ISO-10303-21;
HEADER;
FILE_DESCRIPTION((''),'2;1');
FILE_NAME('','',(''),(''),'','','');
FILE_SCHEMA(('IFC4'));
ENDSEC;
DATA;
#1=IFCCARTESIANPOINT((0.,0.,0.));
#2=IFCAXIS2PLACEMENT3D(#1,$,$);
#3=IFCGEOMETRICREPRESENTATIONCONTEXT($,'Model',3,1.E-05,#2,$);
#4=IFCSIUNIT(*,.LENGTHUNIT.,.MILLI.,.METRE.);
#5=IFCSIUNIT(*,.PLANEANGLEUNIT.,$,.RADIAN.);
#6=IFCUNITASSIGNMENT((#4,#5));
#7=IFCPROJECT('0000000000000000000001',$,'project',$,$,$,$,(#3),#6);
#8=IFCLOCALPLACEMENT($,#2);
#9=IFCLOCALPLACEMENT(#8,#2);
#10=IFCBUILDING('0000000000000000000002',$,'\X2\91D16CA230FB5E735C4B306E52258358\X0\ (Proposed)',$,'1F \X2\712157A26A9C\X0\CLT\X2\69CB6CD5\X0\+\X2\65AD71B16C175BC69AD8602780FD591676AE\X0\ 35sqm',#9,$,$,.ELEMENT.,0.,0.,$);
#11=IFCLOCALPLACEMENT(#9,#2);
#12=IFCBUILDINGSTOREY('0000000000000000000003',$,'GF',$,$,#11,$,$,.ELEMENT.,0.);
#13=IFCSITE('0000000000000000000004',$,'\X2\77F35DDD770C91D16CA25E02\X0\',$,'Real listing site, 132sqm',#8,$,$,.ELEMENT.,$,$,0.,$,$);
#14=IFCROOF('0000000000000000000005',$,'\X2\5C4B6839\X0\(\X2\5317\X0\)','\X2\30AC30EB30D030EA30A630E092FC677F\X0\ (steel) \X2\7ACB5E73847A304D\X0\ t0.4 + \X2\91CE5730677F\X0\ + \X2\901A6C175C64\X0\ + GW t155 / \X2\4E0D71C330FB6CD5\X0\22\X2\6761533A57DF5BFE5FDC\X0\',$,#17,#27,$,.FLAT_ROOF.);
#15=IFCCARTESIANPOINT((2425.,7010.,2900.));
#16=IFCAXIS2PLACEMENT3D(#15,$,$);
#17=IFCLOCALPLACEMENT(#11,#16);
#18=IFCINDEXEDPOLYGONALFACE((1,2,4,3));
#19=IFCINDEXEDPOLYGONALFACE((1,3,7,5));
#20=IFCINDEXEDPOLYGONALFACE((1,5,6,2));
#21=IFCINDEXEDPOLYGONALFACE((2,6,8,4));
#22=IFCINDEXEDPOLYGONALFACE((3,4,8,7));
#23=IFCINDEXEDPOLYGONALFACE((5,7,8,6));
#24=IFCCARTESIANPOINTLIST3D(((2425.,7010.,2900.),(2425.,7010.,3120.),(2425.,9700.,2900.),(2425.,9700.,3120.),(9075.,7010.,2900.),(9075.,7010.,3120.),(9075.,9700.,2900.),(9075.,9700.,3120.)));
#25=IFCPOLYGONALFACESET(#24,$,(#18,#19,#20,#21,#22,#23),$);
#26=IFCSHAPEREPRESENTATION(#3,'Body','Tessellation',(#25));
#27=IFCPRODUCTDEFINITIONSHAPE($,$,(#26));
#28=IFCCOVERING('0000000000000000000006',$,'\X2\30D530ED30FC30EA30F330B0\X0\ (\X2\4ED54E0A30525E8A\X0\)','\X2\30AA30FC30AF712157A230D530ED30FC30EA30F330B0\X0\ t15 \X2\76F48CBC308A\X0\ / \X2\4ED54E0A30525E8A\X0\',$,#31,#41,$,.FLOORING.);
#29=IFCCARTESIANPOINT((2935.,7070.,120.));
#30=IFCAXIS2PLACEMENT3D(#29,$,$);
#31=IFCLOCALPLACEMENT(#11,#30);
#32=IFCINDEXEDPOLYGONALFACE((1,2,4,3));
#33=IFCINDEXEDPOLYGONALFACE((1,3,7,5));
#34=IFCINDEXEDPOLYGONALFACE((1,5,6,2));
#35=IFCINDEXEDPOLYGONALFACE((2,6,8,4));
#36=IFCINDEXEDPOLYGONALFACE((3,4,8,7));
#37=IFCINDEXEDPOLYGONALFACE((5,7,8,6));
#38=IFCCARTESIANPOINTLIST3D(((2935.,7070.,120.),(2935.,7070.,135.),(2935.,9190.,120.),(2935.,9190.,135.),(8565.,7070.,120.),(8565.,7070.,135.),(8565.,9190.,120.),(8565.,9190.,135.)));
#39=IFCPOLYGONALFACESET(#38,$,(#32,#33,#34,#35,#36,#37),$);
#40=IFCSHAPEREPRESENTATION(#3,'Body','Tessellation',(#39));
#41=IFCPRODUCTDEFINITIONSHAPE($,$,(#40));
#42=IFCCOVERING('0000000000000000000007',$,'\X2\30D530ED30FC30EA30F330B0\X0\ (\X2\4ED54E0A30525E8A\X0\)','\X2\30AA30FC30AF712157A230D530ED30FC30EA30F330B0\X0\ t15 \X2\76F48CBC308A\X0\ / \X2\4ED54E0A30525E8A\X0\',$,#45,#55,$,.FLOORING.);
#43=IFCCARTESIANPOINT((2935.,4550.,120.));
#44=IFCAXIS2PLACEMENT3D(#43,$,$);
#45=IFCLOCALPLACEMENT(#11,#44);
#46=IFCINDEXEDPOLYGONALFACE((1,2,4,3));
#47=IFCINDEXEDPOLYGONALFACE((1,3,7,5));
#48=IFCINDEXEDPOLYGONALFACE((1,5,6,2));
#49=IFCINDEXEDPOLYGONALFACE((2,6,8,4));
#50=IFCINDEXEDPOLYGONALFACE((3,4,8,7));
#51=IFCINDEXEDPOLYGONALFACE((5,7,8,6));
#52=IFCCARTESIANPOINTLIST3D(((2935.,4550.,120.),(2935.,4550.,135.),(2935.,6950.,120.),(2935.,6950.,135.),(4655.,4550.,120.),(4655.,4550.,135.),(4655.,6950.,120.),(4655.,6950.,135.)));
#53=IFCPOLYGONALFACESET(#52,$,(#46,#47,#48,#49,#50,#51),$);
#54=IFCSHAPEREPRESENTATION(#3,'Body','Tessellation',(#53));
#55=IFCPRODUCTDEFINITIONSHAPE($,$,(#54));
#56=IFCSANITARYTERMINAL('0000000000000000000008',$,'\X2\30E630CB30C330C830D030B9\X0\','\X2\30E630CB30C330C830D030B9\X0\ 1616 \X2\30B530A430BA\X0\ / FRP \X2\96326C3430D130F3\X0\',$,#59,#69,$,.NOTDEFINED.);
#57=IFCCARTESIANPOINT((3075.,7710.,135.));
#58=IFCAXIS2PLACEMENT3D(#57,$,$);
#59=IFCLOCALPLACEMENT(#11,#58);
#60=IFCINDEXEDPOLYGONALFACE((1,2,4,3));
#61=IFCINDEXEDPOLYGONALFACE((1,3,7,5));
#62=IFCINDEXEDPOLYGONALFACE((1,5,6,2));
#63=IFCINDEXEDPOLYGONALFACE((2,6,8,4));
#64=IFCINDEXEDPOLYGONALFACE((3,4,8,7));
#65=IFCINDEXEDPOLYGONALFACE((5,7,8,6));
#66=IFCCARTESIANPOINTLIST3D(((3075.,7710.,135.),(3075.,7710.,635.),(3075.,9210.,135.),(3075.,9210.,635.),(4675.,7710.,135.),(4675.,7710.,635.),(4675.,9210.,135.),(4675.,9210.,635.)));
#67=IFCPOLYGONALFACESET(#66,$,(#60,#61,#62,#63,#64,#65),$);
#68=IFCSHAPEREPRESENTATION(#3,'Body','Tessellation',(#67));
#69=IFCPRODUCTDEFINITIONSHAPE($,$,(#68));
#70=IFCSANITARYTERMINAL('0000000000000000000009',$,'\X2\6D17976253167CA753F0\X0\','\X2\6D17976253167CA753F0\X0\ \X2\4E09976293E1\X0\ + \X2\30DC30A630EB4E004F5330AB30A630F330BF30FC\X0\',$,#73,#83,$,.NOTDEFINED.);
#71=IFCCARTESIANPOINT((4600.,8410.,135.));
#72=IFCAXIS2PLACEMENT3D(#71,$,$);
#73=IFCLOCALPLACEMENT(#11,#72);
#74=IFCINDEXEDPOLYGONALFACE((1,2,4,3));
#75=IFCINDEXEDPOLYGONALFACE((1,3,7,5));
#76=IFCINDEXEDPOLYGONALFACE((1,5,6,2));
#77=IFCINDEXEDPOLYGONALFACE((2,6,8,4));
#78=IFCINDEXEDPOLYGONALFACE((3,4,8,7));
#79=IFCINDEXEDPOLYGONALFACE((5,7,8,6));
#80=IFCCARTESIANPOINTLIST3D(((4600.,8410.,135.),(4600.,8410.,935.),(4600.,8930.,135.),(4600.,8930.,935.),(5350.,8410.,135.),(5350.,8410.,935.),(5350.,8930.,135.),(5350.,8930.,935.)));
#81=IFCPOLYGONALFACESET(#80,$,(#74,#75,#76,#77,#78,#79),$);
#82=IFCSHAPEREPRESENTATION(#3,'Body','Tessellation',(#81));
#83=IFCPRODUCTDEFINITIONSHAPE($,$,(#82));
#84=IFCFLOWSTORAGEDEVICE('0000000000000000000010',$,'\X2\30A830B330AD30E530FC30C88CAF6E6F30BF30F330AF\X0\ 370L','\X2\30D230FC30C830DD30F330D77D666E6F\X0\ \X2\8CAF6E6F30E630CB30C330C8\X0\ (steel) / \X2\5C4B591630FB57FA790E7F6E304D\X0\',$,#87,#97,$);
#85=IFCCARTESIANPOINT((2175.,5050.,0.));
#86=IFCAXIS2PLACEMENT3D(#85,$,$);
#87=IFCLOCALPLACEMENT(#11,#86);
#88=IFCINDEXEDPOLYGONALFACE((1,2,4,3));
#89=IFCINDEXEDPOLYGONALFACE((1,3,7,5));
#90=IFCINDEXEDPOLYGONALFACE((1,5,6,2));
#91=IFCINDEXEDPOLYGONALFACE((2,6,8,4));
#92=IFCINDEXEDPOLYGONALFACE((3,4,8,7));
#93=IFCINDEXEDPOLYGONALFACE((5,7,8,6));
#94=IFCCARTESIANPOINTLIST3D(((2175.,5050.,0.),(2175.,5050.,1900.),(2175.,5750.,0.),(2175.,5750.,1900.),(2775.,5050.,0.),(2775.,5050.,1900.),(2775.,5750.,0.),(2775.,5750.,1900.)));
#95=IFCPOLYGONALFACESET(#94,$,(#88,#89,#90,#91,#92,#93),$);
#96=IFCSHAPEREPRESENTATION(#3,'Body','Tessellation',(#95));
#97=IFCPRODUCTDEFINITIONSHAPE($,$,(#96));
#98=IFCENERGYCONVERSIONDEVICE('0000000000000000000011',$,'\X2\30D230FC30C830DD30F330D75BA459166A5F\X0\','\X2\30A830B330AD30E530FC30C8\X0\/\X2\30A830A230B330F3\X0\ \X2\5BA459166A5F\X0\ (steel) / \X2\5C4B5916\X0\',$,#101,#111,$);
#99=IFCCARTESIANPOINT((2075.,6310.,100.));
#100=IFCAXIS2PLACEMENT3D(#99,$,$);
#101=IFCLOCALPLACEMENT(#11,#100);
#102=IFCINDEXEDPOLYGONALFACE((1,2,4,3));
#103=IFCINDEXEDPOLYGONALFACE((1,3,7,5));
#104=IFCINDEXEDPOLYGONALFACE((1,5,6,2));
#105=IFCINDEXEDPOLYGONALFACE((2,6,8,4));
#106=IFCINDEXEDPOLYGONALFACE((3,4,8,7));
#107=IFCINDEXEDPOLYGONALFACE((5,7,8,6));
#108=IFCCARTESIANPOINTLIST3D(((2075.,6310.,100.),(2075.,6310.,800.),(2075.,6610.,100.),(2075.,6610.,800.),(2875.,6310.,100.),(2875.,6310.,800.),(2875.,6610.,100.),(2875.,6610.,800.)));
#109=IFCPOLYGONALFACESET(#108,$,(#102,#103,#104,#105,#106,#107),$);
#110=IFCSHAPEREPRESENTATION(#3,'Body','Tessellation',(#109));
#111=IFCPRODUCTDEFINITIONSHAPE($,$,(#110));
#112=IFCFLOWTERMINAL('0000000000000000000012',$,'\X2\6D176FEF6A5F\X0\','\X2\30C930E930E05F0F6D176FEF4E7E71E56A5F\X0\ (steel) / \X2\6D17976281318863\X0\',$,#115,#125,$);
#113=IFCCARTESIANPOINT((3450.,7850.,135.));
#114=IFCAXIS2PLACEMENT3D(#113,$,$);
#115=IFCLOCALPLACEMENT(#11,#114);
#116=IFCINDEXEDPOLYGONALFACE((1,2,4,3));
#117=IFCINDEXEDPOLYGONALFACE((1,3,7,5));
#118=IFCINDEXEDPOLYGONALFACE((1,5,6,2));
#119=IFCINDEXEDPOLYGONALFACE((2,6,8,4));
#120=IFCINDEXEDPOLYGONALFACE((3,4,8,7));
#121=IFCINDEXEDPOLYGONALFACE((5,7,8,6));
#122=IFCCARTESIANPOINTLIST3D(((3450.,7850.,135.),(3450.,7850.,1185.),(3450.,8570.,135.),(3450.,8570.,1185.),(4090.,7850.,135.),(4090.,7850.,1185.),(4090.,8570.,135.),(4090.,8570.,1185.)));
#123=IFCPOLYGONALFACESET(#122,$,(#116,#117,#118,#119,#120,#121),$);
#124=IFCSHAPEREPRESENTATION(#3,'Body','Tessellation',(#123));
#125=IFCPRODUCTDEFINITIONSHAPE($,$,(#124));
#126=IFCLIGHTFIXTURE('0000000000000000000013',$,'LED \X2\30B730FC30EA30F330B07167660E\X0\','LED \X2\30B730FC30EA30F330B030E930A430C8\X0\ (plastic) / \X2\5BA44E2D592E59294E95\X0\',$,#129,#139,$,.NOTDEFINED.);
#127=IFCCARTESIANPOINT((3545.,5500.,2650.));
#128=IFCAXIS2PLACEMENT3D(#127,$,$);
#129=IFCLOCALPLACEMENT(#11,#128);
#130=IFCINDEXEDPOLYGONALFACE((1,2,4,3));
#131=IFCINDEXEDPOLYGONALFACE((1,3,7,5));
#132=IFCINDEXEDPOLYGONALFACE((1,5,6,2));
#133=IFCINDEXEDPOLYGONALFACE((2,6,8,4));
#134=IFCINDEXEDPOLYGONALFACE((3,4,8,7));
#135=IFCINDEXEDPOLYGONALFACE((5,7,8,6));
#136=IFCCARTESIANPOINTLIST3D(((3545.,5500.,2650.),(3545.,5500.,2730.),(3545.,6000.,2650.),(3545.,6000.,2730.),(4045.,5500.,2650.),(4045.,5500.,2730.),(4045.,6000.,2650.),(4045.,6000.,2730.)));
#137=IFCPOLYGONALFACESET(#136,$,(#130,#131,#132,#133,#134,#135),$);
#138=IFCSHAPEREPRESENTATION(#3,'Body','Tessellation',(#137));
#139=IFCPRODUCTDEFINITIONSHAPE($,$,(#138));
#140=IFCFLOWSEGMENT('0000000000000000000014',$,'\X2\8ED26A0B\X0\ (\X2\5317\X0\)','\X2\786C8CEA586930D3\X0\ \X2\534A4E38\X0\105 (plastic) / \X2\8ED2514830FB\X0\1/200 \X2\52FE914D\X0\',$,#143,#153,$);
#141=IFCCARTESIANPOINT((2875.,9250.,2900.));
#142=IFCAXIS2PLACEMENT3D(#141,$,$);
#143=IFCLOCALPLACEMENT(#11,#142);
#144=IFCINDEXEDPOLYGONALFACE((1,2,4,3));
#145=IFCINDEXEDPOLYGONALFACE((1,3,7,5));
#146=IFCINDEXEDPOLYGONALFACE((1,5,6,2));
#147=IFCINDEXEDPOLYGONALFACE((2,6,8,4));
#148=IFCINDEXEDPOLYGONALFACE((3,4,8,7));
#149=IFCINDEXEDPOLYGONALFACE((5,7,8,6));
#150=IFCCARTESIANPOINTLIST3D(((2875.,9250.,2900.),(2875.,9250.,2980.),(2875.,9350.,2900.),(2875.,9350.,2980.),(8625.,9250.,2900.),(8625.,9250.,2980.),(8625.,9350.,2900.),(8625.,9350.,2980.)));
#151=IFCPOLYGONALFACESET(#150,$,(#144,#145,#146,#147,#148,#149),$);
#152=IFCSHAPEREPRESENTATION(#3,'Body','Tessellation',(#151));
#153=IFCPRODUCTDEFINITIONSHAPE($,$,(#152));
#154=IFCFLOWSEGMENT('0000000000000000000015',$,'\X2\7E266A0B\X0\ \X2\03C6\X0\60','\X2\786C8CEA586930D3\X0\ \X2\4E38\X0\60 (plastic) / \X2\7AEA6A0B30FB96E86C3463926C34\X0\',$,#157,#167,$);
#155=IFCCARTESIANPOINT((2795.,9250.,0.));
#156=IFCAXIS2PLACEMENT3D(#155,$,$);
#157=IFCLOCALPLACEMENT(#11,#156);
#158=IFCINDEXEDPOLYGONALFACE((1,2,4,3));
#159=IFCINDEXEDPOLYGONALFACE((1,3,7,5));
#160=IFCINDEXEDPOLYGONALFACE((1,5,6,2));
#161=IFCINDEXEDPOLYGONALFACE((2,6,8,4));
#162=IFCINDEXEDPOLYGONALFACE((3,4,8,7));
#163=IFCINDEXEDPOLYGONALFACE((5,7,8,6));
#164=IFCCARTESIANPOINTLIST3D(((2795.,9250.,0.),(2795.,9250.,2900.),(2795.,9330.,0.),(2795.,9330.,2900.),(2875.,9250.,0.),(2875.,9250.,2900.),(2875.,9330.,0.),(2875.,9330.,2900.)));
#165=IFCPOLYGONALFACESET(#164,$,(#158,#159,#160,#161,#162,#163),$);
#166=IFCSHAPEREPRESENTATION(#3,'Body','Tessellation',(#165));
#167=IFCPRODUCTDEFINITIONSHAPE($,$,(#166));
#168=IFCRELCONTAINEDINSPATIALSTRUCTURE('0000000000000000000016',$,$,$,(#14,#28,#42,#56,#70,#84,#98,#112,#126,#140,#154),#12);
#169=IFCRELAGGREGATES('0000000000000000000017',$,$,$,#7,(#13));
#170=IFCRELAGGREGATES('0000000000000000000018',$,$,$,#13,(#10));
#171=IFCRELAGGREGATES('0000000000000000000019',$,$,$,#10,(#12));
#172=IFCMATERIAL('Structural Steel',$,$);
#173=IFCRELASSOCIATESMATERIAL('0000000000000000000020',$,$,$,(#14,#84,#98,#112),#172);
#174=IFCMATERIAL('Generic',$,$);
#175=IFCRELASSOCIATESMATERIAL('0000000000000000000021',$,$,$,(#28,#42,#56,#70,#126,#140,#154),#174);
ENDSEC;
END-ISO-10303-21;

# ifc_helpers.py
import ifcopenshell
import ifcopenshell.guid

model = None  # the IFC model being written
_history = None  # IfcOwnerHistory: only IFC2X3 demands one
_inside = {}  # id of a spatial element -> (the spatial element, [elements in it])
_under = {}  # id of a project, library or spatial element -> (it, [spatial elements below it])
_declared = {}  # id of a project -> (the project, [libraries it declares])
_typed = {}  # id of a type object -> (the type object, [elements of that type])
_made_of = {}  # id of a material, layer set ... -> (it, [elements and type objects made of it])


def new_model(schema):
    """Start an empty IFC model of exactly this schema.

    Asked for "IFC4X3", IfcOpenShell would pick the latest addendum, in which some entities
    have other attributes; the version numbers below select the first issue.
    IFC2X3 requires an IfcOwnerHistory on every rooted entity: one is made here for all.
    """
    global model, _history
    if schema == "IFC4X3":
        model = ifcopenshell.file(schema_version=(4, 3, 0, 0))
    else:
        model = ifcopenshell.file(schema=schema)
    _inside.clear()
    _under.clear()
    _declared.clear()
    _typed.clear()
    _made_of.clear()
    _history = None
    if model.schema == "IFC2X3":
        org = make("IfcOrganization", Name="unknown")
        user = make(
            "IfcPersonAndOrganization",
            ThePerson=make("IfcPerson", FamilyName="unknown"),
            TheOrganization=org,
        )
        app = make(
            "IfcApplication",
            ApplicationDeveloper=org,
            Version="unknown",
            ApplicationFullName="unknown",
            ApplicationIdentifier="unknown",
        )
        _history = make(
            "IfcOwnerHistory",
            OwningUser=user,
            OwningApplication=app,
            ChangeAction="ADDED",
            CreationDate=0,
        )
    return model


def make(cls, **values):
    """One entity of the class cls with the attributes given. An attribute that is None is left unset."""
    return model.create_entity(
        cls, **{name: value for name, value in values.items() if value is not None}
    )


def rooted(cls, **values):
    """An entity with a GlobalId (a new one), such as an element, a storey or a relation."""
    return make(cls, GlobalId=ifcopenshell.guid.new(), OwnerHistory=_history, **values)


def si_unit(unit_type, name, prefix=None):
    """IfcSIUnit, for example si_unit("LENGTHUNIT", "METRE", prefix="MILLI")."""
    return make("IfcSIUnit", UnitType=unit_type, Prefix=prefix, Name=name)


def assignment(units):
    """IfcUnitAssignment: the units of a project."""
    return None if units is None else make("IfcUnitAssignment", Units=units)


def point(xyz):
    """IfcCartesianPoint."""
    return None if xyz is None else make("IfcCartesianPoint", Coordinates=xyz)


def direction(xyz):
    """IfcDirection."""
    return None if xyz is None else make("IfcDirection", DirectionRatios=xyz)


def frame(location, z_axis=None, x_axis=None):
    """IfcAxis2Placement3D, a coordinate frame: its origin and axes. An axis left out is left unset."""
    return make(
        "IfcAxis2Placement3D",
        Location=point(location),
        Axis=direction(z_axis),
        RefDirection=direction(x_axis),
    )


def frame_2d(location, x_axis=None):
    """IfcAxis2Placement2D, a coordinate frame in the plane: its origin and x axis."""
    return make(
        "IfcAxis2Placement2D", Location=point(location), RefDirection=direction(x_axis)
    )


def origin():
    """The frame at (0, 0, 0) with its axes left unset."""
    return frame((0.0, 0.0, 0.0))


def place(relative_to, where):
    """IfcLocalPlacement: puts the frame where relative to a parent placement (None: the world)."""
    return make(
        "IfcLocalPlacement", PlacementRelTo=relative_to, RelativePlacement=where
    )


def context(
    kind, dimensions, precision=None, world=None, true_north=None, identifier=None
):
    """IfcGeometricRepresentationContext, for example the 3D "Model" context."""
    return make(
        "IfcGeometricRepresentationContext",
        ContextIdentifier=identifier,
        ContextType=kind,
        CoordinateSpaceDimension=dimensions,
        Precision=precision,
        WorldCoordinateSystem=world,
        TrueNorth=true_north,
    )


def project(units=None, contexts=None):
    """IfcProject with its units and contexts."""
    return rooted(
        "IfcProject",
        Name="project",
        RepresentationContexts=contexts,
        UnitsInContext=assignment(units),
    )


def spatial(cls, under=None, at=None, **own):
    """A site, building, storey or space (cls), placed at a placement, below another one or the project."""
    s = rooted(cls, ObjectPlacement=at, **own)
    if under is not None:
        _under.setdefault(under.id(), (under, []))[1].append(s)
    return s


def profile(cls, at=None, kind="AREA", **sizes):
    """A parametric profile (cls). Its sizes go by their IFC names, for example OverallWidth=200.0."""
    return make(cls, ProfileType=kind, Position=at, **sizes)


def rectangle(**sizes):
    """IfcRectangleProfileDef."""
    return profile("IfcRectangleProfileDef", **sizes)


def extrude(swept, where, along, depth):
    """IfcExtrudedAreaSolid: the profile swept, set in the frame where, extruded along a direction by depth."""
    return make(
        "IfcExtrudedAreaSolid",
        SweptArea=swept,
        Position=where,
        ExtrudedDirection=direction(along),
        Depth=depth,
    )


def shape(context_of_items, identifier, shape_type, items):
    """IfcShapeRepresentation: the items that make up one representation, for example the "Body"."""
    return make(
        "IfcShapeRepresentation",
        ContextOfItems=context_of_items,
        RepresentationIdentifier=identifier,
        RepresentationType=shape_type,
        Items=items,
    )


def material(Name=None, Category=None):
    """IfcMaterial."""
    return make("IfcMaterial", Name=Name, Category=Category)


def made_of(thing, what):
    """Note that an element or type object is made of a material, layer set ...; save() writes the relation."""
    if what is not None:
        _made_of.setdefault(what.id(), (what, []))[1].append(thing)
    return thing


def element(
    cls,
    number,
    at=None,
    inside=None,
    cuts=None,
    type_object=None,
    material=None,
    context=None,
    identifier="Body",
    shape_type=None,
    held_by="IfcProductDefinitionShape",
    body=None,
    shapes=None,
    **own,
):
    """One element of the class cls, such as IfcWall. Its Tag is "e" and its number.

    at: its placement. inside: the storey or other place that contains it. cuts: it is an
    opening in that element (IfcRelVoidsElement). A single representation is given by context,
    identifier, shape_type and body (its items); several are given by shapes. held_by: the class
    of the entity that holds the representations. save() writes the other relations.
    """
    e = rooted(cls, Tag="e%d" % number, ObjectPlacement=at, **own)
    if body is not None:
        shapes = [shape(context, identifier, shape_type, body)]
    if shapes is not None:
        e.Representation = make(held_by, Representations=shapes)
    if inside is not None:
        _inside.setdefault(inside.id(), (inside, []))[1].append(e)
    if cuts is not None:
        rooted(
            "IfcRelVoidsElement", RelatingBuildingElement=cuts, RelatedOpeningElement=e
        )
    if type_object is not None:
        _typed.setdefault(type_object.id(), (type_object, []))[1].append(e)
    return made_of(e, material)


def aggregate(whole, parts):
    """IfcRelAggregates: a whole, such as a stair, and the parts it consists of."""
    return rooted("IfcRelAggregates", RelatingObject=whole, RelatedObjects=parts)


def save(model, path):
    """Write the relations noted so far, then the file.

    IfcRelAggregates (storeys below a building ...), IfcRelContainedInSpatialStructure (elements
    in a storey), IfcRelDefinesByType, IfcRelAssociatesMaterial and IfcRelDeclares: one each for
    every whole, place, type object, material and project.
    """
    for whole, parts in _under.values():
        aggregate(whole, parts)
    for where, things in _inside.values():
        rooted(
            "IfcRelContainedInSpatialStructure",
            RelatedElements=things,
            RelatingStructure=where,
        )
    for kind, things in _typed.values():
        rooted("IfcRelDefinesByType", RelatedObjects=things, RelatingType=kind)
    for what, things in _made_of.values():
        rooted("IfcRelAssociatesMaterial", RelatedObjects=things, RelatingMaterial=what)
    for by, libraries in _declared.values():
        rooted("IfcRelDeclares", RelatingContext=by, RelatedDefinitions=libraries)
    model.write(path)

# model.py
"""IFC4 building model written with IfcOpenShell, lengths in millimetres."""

from ifc_helpers import new_model, si_unit, frame, frame_2d, origin, place, context, project, spatial, rectangle, extrude, material, element, save


model = new_model("IFC4")

# Units and contexts
model_context = context("Model", 3, precision=1e-05, world=origin())
ifc_project = project(units=[si_unit("LENGTHUNIT", "METRE", prefix="MILLI"), si_unit("PLANEANGLEUNIT", "RADIAN")], contexts=[model_context])

# Site, building, storey
site_placement = place(None, origin())
site = spatial("IfcSite", under=ifc_project, at=site_placement, Name="石川県金沢市", ObjectType="Real listing site, 132sqm", CompositionType="ELEMENT", RefElevation=0.0)
building_placement = place(site_placement, origin())
building = spatial("IfcBuilding", under=site, at=building_placement, Name="金沢・平屋の別荘 (Proposed)", ObjectType="1F 無垢檜CLT構法+断熱気密高性能外皮 35sqm", CompositionType="ELEMENT", ElevationOfRefHeight=0.0, ElevationOfTerrain=0.0)
storey_placement = place(building_placement, origin())
storey = spatial("IfcBuildingStorey", under=building, at=storey_placement, Name="GF", CompositionType="ELEMENT", Elevation=0.0)

# Roof
ifc_material_1 = material(Name="Structural Steel")
roof_placement = place(storey_placement, frame((2425.0, 7010.0, 2900.0)))
element("IfcRoof", 1, at=roof_placement, inside=storey, material=ifc_material_1, Name="屋根(北)", Description="ガルバリウム鋼板 (steel) 立平葺き t0.4 + 野地板 + 通気層 + GW t155 / 不燃・法22条区域対応", PredefinedType="FLAT_ROOF", context=model_context, shape_type="SweptSolid", body=[
    extrude(rectangle(XDim=6650.0, YDim=2690.0, at=frame_2d((3325.0, 1345.0))), frame((2425.0, 7010.0, 2900.0)), (0.0, 0.0, 1.0), 220.0),
])

# Coverings
ifc_material_2 = material(Name="Generic")
covering_1_placement = place(storey_placement, frame((2935.0, 7070.0, 120.0)))
element("IfcCovering", 2, at=covering_1_placement, inside=storey, material=ifc_material_2, Name="フローリング (仕上げ床)", Description="オーク無垢フローリング t15 直貼り / 仕上げ床", PredefinedType="FLOORING", context=model_context, shape_type="SweptSolid", body=[
    extrude(rectangle(XDim=5630.0, YDim=2120.0, at=frame_2d((2815.0, 1060.0))), frame((2935.0, 7070.0, 120.0)), (0.0, 0.0, 1.0), 15.0),
])
covering_2_placement = place(storey_placement, frame((2935.0, 4550.0, 120.0)))
element("IfcCovering", 3, at=covering_2_placement, inside=storey, material=ifc_material_2, Name="フローリング (仕上げ床)", Description="オーク無垢フローリング t15 直貼り / 仕上げ床", PredefinedType="FLOORING", context=model_context, shape_type="SweptSolid", body=[
    extrude(rectangle(XDim=1720.0, YDim=2400.0, at=frame_2d((860.0, 1200.0))), frame((2935.0, 4550.0, 120.0)), (0.0, 0.0, 1.0), 15.0),
])

# Sanitary terminals
sanitary_terminal_1_placement = place(storey_placement, frame((3075.0, 7710.0, 135.0)))
element("IfcSanitaryTerminal", 4, at=sanitary_terminal_1_placement, inside=storey, material=ifc_material_2, Name="ユニットバス", Description="ユニットバス 1616 サイズ / FRP 防水パン", PredefinedType="NOTDEFINED", context=model_context, shape_type="SweptSolid", body=[
    extrude(rectangle(XDim=1600.0, YDim=1500.0, at=frame_2d((800.0, 750.0))), frame((3075.0, 7710.0, 135.0)), (0.0, 0.0, 1.0), 500.0),
])
sanitary_terminal_2_placement = place(storey_placement, frame((4600.0, 8410.0, 135.0)))
element("IfcSanitaryTerminal", 5, at=sanitary_terminal_2_placement, inside=storey, material=ifc_material_2, Name="洗面化粧台", Description="洗面化粧台 三面鏡 + ボウル一体カウンター", PredefinedType="NOTDEFINED", context=model_context, shape_type="SweptSolid", body=[
    extrude(rectangle(XDim=750.0, YDim=520.0, at=frame_2d((375.0, 260.0))), frame((4600.0, 8410.0, 135.0)), (0.0, 0.0, 1.0), 800.0),
])

# Flow storage device
flow_storage_device_placement = place(storey_placement, frame((2175.0, 5050.0, 0.0)))
element("IfcFlowStorageDevice", 6, at=flow_storage_device_placement, inside=storey, material=ifc_material_1, Name="エコキュート貯湯タンク 370L", Description="ヒートポンプ給湯 貯湯ユニット (steel) / 屋外・基礎置き", context=model_context, shape_type="SweptSolid", body=[
    extrude(rectangle(XDim=600.0, YDim=700.0, at=frame_2d((300.0, 350.0))), frame((2175.0, 5050.0, 0.0)), (0.0, 0.0, 1.0), 1900.0),
])

# Energy conversion device
energy_conversion_device_placement = place(storey_placement, frame((2075.0, 6310.0, 100.0)))
element("IfcEnergyConversionDevice", 7, at=energy_conversion_device_placement, inside=storey, material=ifc_material_1, Name="ヒートポンプ室外機", Description="エコキュート/エアコン 室外機 (steel) / 屋外", context=model_context, shape_type="SweptSolid", body=[
    extrude(rectangle(XDim=800.0, YDim=300.0, at=frame_2d((400.0, 150.0))), frame((2075.0, 6310.0, 100.0)), (0.0, 0.0, 1.0), 700.0),
])

# Flow terminal
flow_terminal_placement = place(storey_placement, frame((3450.0, 7850.0, 135.0)))
element("IfcFlowTerminal", 8, at=flow_terminal_placement, inside=storey, material=ifc_material_1, Name="洗濯機", Description="ドラム式洗濯乾燥機 (steel) / 洗面脱衣", context=model_context, shape_type="SweptSolid", body=[
    extrude(rectangle(XDim=640.0, YDim=720.0, at=frame_2d((320.0, 360.0))), frame((3450.0, 7850.0, 135.0)), (0.0, 0.0, 1.0), 1050.0),
])

# Light fixture
light_fixture_placement = place(storey_placement, frame((3545.0, 5500.0, 2650.0)))
element("IfcLightFixture", 9, at=light_fixture_placement, inside=storey, material=ifc_material_2, Name="LED シーリング照明", Description="LED シーリングライト (plastic) / 室中央天井", PredefinedType="NOTDEFINED", context=model_context, shape_type="SweptSolid", body=[
    extrude(rectangle(XDim=500.0, YDim=500.0, at=frame_2d((250.0, 250.0))), frame((3545.0, 5500.0, 2650.0)), (0.0, 0.0, 1.0), 80.0),
])

# Flow segments
flow_segment_1_placement = place(storey_placement, frame((2875.0, 9250.0, 2900.0)))
element("IfcFlowSegment", 10, at=flow_segment_1_placement, inside=storey, material=ifc_material_2, Name="軒樋 (北)", Description="硬質塩ビ 半丸105 (plastic) / 軒先・1/200 勾配", context=model_context, shape_type="SweptSolid", body=[
    extrude(rectangle(XDim=5750.0, YDim=100.0, at=frame_2d((2875.0, 50.0))), frame((2875.0, 9250.0, 2900.0)), (0.0, 0.0, 1.0), 80.0),
])
flow_segment_2_placement = place(storey_placement, frame((2795.0, 9250.0, 0.0)))
element("IfcFlowSegment", 11, at=flow_segment_2_placement, inside=storey, material=ifc_material_2, Name="縦樋 φ60", Description="硬質塩ビ 丸60 (plastic) / 竪樋・雨水排水", context=model_context, shape_type="SweptSolid", body=[
    extrude(rectangle(XDim=80.0, YDim=80.0, at=frame_2d((40.0, 40.0))), frame((2795.0, 9250.0, 0.0)), (0.0, 0.0, 1.0), 2900.0),
])

save(model, "model.ifc")
